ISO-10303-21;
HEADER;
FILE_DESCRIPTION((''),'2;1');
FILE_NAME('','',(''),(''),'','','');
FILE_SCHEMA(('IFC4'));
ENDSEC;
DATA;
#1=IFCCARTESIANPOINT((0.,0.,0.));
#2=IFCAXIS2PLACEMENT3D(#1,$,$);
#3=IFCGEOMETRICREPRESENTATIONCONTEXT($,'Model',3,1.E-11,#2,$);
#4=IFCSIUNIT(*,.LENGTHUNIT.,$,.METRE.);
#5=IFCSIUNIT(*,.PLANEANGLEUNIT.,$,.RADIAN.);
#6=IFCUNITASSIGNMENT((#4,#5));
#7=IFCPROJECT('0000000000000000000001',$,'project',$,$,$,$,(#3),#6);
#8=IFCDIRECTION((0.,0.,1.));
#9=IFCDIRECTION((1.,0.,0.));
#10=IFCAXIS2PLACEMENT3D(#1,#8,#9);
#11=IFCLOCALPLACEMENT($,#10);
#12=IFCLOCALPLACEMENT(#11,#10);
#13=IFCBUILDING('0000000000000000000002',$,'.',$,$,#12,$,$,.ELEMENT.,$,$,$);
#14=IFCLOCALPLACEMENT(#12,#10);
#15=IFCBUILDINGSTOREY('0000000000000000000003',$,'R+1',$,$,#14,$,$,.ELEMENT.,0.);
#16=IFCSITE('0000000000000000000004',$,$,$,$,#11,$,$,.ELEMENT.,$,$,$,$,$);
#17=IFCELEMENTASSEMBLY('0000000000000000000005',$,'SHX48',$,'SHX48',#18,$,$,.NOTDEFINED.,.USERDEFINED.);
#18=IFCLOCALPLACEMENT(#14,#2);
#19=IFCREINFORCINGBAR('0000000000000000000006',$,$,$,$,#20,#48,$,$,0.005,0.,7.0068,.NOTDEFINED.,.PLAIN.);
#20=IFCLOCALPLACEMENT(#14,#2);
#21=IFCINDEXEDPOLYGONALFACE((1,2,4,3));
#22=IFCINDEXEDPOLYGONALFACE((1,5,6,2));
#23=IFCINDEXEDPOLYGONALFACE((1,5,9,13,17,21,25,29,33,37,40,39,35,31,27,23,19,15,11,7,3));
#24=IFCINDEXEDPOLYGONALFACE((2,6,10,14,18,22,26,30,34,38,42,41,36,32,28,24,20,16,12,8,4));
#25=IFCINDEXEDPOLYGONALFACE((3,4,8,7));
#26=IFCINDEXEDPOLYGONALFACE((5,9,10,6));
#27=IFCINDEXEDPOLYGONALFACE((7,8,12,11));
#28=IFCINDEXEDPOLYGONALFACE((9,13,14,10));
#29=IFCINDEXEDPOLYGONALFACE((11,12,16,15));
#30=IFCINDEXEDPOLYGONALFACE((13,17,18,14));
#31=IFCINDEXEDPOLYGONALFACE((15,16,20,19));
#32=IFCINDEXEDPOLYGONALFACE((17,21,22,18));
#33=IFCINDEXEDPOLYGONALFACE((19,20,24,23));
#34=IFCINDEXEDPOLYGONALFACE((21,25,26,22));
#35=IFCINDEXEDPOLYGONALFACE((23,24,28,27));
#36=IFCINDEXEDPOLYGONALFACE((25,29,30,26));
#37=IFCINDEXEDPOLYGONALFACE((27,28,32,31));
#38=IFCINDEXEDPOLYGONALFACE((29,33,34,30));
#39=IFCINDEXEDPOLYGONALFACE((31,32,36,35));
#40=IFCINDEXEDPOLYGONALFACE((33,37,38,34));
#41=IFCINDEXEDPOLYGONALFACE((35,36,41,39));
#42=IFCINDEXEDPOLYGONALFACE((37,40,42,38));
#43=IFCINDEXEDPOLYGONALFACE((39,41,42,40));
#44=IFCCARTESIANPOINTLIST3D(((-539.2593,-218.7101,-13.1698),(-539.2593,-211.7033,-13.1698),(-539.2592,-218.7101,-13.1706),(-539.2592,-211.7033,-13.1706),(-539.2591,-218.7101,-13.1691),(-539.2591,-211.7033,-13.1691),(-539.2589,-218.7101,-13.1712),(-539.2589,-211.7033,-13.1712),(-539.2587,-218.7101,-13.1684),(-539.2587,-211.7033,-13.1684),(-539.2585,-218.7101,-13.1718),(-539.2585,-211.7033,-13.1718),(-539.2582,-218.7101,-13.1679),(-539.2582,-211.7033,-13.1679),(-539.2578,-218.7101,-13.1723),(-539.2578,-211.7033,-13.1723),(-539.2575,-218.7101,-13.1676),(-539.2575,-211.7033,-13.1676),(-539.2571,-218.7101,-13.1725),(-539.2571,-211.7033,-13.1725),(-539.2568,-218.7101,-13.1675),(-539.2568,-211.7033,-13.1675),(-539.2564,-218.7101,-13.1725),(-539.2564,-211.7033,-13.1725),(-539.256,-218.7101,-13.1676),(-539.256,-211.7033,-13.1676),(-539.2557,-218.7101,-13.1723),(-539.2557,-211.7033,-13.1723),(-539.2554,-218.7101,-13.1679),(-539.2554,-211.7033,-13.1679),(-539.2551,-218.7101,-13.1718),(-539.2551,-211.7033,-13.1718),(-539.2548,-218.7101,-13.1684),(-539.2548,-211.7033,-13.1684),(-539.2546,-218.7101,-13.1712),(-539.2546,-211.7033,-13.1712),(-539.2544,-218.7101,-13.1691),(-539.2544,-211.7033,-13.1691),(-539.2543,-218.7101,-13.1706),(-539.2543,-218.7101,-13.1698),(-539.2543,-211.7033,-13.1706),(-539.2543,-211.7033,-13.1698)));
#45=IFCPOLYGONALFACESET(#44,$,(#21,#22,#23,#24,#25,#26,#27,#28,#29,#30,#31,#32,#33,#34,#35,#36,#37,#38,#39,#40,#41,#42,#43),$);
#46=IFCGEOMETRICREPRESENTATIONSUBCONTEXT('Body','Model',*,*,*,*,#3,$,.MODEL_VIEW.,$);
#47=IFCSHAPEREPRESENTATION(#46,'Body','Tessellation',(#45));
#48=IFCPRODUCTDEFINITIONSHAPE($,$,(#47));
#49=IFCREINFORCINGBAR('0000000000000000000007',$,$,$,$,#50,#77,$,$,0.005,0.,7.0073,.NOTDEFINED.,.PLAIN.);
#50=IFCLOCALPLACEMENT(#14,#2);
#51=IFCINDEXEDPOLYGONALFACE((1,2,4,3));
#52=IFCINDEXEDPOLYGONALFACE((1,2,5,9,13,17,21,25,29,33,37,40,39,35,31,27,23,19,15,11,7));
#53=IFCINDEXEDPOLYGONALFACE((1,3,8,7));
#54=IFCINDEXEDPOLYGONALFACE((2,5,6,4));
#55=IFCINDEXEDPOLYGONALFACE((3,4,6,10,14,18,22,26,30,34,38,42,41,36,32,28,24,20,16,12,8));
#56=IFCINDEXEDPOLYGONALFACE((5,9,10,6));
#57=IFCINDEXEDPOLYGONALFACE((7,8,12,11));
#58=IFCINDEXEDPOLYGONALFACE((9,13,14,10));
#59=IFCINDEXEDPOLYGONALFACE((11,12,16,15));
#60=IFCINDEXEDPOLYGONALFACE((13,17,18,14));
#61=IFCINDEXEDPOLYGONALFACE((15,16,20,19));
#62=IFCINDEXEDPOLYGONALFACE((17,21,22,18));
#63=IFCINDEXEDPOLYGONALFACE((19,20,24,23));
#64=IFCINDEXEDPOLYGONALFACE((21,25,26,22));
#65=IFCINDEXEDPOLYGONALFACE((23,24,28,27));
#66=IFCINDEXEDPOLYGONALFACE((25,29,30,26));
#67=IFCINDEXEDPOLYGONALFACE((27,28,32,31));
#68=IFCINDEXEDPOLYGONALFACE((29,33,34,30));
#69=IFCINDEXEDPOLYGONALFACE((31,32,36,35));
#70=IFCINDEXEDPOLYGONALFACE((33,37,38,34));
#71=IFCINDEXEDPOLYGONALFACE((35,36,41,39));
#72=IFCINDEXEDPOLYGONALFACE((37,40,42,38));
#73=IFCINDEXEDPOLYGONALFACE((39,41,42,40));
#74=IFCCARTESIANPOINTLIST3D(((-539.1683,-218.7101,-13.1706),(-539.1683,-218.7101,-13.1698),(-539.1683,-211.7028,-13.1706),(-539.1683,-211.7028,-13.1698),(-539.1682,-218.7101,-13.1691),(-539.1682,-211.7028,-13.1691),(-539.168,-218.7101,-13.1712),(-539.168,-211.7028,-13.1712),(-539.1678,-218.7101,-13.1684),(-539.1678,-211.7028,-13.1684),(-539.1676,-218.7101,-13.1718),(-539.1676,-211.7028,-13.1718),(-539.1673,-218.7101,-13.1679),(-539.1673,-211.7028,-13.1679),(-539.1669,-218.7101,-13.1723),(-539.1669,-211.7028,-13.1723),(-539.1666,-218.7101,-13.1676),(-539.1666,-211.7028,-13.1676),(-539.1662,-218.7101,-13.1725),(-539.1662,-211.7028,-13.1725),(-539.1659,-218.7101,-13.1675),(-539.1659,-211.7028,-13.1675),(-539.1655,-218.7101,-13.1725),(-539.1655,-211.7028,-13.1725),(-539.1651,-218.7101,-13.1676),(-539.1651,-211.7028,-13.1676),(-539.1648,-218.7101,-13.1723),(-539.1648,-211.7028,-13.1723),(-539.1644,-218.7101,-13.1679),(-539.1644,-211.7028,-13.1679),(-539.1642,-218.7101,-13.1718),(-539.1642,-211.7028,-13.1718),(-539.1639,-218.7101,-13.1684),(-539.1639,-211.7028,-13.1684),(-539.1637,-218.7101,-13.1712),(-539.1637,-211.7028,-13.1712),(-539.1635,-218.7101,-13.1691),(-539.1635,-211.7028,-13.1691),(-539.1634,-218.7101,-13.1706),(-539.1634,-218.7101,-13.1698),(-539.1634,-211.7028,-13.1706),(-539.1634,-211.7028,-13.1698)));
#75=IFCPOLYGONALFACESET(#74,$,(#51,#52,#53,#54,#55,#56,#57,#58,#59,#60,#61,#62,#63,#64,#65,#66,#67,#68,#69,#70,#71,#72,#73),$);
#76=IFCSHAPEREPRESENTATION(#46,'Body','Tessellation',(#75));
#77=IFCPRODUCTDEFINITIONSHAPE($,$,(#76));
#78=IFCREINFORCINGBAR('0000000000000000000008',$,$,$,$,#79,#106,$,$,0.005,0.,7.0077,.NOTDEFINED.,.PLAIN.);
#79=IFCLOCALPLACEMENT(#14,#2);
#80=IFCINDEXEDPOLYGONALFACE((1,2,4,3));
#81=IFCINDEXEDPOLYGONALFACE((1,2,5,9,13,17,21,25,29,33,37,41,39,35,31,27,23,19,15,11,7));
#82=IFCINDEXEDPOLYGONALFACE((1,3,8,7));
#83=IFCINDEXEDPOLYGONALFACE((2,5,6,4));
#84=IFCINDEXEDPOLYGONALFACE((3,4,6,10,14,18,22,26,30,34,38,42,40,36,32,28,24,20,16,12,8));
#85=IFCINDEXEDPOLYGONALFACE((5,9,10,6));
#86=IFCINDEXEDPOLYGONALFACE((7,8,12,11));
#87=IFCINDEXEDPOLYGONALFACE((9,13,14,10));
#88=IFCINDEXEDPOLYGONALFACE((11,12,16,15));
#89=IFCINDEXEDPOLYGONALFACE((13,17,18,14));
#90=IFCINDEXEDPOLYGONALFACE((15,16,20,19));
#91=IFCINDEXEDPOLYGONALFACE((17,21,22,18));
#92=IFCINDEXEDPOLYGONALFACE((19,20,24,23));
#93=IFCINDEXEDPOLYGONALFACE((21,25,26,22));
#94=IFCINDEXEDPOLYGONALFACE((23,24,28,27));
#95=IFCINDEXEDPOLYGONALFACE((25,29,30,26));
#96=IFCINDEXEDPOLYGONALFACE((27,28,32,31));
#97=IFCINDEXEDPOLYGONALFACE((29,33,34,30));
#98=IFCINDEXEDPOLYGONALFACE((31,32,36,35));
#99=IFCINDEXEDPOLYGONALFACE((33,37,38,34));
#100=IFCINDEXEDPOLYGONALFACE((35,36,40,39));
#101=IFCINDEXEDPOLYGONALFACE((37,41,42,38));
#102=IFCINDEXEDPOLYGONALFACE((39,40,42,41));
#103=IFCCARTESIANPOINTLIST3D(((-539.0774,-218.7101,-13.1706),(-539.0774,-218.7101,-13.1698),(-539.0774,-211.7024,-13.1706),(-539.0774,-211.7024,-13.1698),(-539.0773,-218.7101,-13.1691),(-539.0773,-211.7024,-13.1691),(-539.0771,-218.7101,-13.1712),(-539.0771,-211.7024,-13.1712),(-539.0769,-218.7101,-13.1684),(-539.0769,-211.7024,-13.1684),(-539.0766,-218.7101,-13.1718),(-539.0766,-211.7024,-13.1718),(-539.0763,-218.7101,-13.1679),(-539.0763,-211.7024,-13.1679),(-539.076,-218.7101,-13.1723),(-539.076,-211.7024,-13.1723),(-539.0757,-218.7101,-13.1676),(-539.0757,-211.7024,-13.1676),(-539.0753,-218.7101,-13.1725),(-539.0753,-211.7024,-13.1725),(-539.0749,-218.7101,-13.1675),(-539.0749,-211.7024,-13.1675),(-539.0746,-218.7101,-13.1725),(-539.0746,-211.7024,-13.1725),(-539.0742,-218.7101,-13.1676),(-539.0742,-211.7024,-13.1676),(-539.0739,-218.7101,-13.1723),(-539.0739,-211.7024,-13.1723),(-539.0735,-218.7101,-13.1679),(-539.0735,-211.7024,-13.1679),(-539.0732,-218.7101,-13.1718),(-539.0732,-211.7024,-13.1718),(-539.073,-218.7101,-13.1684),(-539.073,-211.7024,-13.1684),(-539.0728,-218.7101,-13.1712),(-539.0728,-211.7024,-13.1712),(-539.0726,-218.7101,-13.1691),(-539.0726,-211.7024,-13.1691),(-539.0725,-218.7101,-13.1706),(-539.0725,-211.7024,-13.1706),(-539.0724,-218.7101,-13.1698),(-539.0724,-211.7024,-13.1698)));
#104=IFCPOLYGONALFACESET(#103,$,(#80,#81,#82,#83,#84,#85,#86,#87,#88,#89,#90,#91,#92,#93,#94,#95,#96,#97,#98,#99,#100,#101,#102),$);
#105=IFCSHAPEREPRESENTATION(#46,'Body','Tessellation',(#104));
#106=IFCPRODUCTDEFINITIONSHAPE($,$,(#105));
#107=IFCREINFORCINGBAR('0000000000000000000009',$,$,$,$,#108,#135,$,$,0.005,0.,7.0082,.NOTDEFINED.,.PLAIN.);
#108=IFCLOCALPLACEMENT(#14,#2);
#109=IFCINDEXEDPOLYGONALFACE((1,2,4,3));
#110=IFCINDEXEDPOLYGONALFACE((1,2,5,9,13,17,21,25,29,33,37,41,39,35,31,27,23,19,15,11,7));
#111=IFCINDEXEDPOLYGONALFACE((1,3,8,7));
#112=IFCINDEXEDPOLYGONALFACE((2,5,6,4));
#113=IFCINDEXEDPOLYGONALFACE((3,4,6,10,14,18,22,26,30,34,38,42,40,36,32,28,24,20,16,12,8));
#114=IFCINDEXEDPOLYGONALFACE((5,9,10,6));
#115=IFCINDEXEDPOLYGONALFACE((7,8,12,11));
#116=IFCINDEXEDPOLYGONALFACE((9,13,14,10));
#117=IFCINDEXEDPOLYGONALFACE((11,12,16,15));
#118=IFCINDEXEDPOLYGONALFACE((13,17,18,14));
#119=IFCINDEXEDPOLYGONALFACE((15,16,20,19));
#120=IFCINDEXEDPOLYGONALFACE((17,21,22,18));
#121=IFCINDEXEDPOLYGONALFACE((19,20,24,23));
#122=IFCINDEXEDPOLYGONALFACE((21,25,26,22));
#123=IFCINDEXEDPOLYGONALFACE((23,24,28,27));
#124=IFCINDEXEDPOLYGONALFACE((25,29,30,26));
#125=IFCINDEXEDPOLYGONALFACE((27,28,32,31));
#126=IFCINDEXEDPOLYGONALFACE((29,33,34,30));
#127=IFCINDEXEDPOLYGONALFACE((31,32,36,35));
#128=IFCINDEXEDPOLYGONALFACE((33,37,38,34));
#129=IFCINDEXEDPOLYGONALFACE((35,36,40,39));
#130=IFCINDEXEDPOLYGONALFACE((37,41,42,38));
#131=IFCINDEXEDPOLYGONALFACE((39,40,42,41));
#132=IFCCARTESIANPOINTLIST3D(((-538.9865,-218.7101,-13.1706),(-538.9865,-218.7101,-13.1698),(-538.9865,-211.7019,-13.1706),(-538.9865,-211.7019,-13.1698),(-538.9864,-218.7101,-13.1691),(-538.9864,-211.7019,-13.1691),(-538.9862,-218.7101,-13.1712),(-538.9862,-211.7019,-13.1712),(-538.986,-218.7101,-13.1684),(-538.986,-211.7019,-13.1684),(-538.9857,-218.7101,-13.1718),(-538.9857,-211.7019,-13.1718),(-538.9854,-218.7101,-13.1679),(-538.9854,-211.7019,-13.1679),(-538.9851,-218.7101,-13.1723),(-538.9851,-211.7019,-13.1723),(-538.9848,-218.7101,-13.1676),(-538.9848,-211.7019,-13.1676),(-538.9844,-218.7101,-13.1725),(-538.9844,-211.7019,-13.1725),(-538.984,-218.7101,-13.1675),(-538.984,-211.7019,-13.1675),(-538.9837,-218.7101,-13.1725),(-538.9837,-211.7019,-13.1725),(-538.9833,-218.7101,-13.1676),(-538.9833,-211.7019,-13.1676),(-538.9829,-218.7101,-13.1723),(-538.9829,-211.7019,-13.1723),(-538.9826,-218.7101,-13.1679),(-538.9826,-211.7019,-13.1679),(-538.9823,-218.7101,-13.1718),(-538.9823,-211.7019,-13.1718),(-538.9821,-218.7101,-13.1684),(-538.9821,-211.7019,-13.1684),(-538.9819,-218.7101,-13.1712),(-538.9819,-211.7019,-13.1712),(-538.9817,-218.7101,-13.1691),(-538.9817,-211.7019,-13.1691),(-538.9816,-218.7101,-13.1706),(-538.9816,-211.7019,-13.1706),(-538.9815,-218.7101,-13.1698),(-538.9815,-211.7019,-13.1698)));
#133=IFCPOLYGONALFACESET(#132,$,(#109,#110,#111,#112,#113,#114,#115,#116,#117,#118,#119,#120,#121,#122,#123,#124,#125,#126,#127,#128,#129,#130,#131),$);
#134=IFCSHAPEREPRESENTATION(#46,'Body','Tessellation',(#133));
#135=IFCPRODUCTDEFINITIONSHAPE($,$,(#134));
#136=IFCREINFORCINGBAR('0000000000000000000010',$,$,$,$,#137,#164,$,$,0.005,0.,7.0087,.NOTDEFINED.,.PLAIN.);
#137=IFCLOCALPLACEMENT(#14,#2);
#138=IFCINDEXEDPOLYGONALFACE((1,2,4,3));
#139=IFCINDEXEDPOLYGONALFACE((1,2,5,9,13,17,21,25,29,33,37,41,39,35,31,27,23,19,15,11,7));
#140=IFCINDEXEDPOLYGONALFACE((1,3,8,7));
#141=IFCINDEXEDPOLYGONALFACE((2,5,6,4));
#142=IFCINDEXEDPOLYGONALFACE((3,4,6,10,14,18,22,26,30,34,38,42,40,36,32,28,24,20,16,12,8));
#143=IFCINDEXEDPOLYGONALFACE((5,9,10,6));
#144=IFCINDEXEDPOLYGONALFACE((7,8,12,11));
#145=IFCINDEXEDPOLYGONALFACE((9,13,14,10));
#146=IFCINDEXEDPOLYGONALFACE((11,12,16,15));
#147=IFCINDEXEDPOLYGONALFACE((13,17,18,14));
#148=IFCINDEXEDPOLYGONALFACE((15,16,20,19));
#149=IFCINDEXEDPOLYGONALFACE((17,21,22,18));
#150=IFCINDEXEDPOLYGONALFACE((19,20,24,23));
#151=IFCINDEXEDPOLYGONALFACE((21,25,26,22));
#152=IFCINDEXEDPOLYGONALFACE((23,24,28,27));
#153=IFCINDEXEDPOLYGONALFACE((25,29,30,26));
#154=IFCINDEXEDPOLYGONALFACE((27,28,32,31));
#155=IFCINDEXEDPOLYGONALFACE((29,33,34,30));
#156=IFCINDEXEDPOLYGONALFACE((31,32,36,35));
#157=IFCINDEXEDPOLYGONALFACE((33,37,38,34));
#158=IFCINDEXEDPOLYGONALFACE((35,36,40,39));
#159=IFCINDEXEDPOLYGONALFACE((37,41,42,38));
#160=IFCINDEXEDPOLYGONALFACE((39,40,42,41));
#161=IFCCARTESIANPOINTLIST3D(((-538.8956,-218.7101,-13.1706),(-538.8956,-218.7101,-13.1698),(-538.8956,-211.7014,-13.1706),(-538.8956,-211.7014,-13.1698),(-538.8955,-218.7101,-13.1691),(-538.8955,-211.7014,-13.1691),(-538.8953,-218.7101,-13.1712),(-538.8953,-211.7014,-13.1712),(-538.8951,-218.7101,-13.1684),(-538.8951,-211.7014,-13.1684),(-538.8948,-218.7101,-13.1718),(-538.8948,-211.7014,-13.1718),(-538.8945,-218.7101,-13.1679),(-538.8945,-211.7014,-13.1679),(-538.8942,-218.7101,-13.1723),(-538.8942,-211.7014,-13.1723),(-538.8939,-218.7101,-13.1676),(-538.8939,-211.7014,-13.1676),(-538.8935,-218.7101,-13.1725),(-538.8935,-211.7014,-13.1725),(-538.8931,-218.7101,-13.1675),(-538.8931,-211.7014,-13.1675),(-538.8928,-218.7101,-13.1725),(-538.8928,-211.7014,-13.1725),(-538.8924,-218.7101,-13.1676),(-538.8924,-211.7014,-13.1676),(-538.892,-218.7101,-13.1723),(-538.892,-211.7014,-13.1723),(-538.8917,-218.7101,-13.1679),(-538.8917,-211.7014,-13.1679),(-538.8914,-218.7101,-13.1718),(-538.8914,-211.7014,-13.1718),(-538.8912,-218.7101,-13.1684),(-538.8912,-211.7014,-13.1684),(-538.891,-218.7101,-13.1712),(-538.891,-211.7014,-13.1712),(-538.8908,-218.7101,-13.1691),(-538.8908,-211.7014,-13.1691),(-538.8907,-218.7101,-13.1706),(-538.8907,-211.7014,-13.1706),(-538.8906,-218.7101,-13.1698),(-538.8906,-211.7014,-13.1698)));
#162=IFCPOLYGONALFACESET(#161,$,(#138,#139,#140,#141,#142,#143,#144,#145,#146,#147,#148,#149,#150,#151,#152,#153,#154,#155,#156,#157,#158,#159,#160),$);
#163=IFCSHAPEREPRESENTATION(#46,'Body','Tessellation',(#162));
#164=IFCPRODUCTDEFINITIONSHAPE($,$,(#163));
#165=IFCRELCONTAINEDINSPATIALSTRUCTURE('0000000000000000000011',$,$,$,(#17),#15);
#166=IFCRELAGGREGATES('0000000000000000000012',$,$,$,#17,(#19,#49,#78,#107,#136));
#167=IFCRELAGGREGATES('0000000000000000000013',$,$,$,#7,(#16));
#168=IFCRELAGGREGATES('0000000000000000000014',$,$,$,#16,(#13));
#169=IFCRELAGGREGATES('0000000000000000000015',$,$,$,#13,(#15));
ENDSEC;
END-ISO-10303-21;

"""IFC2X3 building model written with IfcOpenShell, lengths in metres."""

from ifc_helpers import new_model, entity, si_unit, origin, origin_with_axes, place, context, subcontext, project, spatial, shape, element, aggregate, save


model = new_model("IFC2X3")

# Units and contexts
model_context = context("Model", 3, precision=1e-11, world=origin())
body_context = subcontext(model_context, "Body", "Model", "MODEL_VIEW")
ifc_project = project(units=[si_unit("LENGTHUNIT", "METRE"), si_unit("PLANEANGLEUNIT", "RADIAN")], contexts=[model_context])

# Site, building, storey
site_placement = place(None, origin_with_axes())
site = spatial("IfcSite", under=ifc_project, at=site_placement, CompositionType="ELEMENT")
building_placement = place(site_placement, origin_with_axes())
building = spatial("IfcBuilding", under=site, at=building_placement, Name=".", CompositionType="ELEMENT")
storey_placement = place(building_placement, origin_with_axes())
storey = spatial("IfcBuildingStorey", under=building, at=storey_placement, Name="R+1", CompositionType="ELEMENT", Elevation=0.0)

# Element assembly, reinforcing bars
assembly_1_placement = place(storey_placement, origin_with_axes())
assembly_1 = element("IfcElementAssembly", 1, at=assembly_1_placement, inside=storey, Name="SHX48", ObjectType="SHX48", AssemblyPlace="NOTDEFINED", PredefinedType="USERDEFINED")
reinforcing_bar_1_placement = place(assembly_1_placement, origin_with_axes())
reinforcing_bar_1 = element("IfcReinforcingBar", 2, at=reinforcing_bar_1_placement, BarLength=7.0068, BarRole="NOTDEFINED", BarSurface="PLAIN", CrossSectionArea=0.0, NominalDiameter=0.005, shapes=[
    shape(body_context, "Body", "AdvancedSweptSolid", [entity("IfcSweptDiskSolid", entity("IfcPolyline", [entity("IfcCartesianPoint", [539.2568, 211.7033, 13.17]), entity("IfcCartesianPoint", [539.2568, 218.7101, 13.17])]), 0.0025, None, 0.0, 7.0068)]),
    shape(body_context, "Body", "AdvancedSweptSolid", [entity("IfcSweptDiskSolid", entity("IfcPolyline", [entity("IfcCartesianPoint", [539.2568, 211.7033, 13.17]), entity("IfcCartesianPoint", [539.2568, 218.7101, 13.17])]), 0.0025, None, 0.0, 7.0068)]),
])
reinforcing_bar_2_placement = place(assembly_1_placement, origin_with_axes())
reinforcing_bar_2 = element("IfcReinforcingBar", 3, at=reinforcing_bar_2_placement, BarLength=7.0073, BarRole="NOTDEFINED", BarSurface="PLAIN", CrossSectionArea=0.0, NominalDiameter=0.005, shapes=[
    shape(body_context, "Body", "AdvancedSweptSolid", [entity("IfcSweptDiskSolid", entity("IfcPolyline", [entity("IfcCartesianPoint", [539.1659, 211.7028, 13.17]), entity("IfcCartesianPoint", [539.1659, 218.7101, 13.17])]), 0.0025, None, 0.0, 7.0073)]),
    shape(body_context, "Body", "AdvancedSweptSolid", [entity("IfcSweptDiskSolid", entity("IfcPolyline", [entity("IfcCartesianPoint", [539.1659, 211.7028, 13.17]), entity("IfcCartesianPoint", [539.1659, 218.7101, 13.17])]), 0.0025, None, 0.0, 7.0073)]),
])
reinforcing_bar_3_placement = place(assembly_1_placement, origin_with_axes())
reinforcing_bar_3 = element("IfcReinforcingBar", 4, at=reinforcing_bar_3_placement, BarLength=7.0077, BarRole="NOTDEFINED", BarSurface="PLAIN", CrossSectionArea=0.0, NominalDiameter=0.005, shapes=[
    shape(body_context, "Body", "AdvancedSweptSolid", [entity("IfcSweptDiskSolid", entity("IfcPolyline", [entity("IfcCartesianPoint", [539.0749, 211.7024, 13.17]), entity("IfcCartesianPoint", [539.0749, 218.7101, 13.17])]), 0.0025, None, 0.0, 7.0077)]),
    shape(body_context, "Body", "AdvancedSweptSolid", [entity("IfcSweptDiskSolid", entity("IfcPolyline", [entity("IfcCartesianPoint", [539.0749, 211.7024, 13.17]), entity("IfcCartesianPoint", [539.0749, 218.7101, 13.17])]), 0.0025, None, 0.0, 7.0077)]),
])
reinforcing_bar_4_placement = place(assembly_1_placement, origin_with_axes())
reinforcing_bar_4 = element("IfcReinforcingBar", 5, at=reinforcing_bar_4_placement, BarLength=7.0082, BarRole="NOTDEFINED", BarSurface="PLAIN", CrossSectionArea=0.0, NominalDiameter=0.005, shapes=[
    shape(body_context, "Body", "AdvancedSweptSolid", [entity("IfcSweptDiskSolid", entity("IfcPolyline", [entity("IfcCartesianPoint", [538.984, 211.7019, 13.17]), entity("IfcCartesianPoint", [538.984, 218.7101, 13.17])]), 0.0025, None, 0.0, 7.0082)]),
    shape(body_context, "Body", "AdvancedSweptSolid", [entity("IfcSweptDiskSolid", entity("IfcPolyline", [entity("IfcCartesianPoint", [538.984, 211.7019, 13.17]), entity("IfcCartesianPoint", [538.984, 218.7101, 13.17])]), 0.0025, None, 0.0, 7.0082)]),
])
reinforcing_bar_5_placement = place(assembly_1_placement, origin_with_axes())
reinforcing_bar_5 = element("IfcReinforcingBar", 6, at=reinforcing_bar_5_placement, BarLength=7.0087, BarRole="NOTDEFINED", BarSurface="PLAIN", CrossSectionArea=0.0, NominalDiameter=0.005, shapes=[
    shape(body_context, "Body", "AdvancedSweptSolid", [entity("IfcSweptDiskSolid", entity("IfcPolyline", [entity("IfcCartesianPoint", [538.8931, 211.7014, 13.17]), entity("IfcCartesianPoint", [538.8931, 218.7101, 13.17])]), 0.0025, None, 0.0, 7.0087)]),
    shape(body_context, "Body", "AdvancedSweptSolid", [entity("IfcSweptDiskSolid", entity("IfcPolyline", [entity("IfcCartesianPoint", [538.8931, 211.7014, 13.17]), entity("IfcCartesianPoint", [538.8931, 218.7101, 13.17])]), 0.0025, None, 0.0, 7.0087)]),
])
aggregate(assembly_1, [reinforcing_bar_1, reinforcing_bar_2, reinforcing_bar_3, reinforcing_bar_4, reinforcing_bar_5])

save(model, "model.ifc")
